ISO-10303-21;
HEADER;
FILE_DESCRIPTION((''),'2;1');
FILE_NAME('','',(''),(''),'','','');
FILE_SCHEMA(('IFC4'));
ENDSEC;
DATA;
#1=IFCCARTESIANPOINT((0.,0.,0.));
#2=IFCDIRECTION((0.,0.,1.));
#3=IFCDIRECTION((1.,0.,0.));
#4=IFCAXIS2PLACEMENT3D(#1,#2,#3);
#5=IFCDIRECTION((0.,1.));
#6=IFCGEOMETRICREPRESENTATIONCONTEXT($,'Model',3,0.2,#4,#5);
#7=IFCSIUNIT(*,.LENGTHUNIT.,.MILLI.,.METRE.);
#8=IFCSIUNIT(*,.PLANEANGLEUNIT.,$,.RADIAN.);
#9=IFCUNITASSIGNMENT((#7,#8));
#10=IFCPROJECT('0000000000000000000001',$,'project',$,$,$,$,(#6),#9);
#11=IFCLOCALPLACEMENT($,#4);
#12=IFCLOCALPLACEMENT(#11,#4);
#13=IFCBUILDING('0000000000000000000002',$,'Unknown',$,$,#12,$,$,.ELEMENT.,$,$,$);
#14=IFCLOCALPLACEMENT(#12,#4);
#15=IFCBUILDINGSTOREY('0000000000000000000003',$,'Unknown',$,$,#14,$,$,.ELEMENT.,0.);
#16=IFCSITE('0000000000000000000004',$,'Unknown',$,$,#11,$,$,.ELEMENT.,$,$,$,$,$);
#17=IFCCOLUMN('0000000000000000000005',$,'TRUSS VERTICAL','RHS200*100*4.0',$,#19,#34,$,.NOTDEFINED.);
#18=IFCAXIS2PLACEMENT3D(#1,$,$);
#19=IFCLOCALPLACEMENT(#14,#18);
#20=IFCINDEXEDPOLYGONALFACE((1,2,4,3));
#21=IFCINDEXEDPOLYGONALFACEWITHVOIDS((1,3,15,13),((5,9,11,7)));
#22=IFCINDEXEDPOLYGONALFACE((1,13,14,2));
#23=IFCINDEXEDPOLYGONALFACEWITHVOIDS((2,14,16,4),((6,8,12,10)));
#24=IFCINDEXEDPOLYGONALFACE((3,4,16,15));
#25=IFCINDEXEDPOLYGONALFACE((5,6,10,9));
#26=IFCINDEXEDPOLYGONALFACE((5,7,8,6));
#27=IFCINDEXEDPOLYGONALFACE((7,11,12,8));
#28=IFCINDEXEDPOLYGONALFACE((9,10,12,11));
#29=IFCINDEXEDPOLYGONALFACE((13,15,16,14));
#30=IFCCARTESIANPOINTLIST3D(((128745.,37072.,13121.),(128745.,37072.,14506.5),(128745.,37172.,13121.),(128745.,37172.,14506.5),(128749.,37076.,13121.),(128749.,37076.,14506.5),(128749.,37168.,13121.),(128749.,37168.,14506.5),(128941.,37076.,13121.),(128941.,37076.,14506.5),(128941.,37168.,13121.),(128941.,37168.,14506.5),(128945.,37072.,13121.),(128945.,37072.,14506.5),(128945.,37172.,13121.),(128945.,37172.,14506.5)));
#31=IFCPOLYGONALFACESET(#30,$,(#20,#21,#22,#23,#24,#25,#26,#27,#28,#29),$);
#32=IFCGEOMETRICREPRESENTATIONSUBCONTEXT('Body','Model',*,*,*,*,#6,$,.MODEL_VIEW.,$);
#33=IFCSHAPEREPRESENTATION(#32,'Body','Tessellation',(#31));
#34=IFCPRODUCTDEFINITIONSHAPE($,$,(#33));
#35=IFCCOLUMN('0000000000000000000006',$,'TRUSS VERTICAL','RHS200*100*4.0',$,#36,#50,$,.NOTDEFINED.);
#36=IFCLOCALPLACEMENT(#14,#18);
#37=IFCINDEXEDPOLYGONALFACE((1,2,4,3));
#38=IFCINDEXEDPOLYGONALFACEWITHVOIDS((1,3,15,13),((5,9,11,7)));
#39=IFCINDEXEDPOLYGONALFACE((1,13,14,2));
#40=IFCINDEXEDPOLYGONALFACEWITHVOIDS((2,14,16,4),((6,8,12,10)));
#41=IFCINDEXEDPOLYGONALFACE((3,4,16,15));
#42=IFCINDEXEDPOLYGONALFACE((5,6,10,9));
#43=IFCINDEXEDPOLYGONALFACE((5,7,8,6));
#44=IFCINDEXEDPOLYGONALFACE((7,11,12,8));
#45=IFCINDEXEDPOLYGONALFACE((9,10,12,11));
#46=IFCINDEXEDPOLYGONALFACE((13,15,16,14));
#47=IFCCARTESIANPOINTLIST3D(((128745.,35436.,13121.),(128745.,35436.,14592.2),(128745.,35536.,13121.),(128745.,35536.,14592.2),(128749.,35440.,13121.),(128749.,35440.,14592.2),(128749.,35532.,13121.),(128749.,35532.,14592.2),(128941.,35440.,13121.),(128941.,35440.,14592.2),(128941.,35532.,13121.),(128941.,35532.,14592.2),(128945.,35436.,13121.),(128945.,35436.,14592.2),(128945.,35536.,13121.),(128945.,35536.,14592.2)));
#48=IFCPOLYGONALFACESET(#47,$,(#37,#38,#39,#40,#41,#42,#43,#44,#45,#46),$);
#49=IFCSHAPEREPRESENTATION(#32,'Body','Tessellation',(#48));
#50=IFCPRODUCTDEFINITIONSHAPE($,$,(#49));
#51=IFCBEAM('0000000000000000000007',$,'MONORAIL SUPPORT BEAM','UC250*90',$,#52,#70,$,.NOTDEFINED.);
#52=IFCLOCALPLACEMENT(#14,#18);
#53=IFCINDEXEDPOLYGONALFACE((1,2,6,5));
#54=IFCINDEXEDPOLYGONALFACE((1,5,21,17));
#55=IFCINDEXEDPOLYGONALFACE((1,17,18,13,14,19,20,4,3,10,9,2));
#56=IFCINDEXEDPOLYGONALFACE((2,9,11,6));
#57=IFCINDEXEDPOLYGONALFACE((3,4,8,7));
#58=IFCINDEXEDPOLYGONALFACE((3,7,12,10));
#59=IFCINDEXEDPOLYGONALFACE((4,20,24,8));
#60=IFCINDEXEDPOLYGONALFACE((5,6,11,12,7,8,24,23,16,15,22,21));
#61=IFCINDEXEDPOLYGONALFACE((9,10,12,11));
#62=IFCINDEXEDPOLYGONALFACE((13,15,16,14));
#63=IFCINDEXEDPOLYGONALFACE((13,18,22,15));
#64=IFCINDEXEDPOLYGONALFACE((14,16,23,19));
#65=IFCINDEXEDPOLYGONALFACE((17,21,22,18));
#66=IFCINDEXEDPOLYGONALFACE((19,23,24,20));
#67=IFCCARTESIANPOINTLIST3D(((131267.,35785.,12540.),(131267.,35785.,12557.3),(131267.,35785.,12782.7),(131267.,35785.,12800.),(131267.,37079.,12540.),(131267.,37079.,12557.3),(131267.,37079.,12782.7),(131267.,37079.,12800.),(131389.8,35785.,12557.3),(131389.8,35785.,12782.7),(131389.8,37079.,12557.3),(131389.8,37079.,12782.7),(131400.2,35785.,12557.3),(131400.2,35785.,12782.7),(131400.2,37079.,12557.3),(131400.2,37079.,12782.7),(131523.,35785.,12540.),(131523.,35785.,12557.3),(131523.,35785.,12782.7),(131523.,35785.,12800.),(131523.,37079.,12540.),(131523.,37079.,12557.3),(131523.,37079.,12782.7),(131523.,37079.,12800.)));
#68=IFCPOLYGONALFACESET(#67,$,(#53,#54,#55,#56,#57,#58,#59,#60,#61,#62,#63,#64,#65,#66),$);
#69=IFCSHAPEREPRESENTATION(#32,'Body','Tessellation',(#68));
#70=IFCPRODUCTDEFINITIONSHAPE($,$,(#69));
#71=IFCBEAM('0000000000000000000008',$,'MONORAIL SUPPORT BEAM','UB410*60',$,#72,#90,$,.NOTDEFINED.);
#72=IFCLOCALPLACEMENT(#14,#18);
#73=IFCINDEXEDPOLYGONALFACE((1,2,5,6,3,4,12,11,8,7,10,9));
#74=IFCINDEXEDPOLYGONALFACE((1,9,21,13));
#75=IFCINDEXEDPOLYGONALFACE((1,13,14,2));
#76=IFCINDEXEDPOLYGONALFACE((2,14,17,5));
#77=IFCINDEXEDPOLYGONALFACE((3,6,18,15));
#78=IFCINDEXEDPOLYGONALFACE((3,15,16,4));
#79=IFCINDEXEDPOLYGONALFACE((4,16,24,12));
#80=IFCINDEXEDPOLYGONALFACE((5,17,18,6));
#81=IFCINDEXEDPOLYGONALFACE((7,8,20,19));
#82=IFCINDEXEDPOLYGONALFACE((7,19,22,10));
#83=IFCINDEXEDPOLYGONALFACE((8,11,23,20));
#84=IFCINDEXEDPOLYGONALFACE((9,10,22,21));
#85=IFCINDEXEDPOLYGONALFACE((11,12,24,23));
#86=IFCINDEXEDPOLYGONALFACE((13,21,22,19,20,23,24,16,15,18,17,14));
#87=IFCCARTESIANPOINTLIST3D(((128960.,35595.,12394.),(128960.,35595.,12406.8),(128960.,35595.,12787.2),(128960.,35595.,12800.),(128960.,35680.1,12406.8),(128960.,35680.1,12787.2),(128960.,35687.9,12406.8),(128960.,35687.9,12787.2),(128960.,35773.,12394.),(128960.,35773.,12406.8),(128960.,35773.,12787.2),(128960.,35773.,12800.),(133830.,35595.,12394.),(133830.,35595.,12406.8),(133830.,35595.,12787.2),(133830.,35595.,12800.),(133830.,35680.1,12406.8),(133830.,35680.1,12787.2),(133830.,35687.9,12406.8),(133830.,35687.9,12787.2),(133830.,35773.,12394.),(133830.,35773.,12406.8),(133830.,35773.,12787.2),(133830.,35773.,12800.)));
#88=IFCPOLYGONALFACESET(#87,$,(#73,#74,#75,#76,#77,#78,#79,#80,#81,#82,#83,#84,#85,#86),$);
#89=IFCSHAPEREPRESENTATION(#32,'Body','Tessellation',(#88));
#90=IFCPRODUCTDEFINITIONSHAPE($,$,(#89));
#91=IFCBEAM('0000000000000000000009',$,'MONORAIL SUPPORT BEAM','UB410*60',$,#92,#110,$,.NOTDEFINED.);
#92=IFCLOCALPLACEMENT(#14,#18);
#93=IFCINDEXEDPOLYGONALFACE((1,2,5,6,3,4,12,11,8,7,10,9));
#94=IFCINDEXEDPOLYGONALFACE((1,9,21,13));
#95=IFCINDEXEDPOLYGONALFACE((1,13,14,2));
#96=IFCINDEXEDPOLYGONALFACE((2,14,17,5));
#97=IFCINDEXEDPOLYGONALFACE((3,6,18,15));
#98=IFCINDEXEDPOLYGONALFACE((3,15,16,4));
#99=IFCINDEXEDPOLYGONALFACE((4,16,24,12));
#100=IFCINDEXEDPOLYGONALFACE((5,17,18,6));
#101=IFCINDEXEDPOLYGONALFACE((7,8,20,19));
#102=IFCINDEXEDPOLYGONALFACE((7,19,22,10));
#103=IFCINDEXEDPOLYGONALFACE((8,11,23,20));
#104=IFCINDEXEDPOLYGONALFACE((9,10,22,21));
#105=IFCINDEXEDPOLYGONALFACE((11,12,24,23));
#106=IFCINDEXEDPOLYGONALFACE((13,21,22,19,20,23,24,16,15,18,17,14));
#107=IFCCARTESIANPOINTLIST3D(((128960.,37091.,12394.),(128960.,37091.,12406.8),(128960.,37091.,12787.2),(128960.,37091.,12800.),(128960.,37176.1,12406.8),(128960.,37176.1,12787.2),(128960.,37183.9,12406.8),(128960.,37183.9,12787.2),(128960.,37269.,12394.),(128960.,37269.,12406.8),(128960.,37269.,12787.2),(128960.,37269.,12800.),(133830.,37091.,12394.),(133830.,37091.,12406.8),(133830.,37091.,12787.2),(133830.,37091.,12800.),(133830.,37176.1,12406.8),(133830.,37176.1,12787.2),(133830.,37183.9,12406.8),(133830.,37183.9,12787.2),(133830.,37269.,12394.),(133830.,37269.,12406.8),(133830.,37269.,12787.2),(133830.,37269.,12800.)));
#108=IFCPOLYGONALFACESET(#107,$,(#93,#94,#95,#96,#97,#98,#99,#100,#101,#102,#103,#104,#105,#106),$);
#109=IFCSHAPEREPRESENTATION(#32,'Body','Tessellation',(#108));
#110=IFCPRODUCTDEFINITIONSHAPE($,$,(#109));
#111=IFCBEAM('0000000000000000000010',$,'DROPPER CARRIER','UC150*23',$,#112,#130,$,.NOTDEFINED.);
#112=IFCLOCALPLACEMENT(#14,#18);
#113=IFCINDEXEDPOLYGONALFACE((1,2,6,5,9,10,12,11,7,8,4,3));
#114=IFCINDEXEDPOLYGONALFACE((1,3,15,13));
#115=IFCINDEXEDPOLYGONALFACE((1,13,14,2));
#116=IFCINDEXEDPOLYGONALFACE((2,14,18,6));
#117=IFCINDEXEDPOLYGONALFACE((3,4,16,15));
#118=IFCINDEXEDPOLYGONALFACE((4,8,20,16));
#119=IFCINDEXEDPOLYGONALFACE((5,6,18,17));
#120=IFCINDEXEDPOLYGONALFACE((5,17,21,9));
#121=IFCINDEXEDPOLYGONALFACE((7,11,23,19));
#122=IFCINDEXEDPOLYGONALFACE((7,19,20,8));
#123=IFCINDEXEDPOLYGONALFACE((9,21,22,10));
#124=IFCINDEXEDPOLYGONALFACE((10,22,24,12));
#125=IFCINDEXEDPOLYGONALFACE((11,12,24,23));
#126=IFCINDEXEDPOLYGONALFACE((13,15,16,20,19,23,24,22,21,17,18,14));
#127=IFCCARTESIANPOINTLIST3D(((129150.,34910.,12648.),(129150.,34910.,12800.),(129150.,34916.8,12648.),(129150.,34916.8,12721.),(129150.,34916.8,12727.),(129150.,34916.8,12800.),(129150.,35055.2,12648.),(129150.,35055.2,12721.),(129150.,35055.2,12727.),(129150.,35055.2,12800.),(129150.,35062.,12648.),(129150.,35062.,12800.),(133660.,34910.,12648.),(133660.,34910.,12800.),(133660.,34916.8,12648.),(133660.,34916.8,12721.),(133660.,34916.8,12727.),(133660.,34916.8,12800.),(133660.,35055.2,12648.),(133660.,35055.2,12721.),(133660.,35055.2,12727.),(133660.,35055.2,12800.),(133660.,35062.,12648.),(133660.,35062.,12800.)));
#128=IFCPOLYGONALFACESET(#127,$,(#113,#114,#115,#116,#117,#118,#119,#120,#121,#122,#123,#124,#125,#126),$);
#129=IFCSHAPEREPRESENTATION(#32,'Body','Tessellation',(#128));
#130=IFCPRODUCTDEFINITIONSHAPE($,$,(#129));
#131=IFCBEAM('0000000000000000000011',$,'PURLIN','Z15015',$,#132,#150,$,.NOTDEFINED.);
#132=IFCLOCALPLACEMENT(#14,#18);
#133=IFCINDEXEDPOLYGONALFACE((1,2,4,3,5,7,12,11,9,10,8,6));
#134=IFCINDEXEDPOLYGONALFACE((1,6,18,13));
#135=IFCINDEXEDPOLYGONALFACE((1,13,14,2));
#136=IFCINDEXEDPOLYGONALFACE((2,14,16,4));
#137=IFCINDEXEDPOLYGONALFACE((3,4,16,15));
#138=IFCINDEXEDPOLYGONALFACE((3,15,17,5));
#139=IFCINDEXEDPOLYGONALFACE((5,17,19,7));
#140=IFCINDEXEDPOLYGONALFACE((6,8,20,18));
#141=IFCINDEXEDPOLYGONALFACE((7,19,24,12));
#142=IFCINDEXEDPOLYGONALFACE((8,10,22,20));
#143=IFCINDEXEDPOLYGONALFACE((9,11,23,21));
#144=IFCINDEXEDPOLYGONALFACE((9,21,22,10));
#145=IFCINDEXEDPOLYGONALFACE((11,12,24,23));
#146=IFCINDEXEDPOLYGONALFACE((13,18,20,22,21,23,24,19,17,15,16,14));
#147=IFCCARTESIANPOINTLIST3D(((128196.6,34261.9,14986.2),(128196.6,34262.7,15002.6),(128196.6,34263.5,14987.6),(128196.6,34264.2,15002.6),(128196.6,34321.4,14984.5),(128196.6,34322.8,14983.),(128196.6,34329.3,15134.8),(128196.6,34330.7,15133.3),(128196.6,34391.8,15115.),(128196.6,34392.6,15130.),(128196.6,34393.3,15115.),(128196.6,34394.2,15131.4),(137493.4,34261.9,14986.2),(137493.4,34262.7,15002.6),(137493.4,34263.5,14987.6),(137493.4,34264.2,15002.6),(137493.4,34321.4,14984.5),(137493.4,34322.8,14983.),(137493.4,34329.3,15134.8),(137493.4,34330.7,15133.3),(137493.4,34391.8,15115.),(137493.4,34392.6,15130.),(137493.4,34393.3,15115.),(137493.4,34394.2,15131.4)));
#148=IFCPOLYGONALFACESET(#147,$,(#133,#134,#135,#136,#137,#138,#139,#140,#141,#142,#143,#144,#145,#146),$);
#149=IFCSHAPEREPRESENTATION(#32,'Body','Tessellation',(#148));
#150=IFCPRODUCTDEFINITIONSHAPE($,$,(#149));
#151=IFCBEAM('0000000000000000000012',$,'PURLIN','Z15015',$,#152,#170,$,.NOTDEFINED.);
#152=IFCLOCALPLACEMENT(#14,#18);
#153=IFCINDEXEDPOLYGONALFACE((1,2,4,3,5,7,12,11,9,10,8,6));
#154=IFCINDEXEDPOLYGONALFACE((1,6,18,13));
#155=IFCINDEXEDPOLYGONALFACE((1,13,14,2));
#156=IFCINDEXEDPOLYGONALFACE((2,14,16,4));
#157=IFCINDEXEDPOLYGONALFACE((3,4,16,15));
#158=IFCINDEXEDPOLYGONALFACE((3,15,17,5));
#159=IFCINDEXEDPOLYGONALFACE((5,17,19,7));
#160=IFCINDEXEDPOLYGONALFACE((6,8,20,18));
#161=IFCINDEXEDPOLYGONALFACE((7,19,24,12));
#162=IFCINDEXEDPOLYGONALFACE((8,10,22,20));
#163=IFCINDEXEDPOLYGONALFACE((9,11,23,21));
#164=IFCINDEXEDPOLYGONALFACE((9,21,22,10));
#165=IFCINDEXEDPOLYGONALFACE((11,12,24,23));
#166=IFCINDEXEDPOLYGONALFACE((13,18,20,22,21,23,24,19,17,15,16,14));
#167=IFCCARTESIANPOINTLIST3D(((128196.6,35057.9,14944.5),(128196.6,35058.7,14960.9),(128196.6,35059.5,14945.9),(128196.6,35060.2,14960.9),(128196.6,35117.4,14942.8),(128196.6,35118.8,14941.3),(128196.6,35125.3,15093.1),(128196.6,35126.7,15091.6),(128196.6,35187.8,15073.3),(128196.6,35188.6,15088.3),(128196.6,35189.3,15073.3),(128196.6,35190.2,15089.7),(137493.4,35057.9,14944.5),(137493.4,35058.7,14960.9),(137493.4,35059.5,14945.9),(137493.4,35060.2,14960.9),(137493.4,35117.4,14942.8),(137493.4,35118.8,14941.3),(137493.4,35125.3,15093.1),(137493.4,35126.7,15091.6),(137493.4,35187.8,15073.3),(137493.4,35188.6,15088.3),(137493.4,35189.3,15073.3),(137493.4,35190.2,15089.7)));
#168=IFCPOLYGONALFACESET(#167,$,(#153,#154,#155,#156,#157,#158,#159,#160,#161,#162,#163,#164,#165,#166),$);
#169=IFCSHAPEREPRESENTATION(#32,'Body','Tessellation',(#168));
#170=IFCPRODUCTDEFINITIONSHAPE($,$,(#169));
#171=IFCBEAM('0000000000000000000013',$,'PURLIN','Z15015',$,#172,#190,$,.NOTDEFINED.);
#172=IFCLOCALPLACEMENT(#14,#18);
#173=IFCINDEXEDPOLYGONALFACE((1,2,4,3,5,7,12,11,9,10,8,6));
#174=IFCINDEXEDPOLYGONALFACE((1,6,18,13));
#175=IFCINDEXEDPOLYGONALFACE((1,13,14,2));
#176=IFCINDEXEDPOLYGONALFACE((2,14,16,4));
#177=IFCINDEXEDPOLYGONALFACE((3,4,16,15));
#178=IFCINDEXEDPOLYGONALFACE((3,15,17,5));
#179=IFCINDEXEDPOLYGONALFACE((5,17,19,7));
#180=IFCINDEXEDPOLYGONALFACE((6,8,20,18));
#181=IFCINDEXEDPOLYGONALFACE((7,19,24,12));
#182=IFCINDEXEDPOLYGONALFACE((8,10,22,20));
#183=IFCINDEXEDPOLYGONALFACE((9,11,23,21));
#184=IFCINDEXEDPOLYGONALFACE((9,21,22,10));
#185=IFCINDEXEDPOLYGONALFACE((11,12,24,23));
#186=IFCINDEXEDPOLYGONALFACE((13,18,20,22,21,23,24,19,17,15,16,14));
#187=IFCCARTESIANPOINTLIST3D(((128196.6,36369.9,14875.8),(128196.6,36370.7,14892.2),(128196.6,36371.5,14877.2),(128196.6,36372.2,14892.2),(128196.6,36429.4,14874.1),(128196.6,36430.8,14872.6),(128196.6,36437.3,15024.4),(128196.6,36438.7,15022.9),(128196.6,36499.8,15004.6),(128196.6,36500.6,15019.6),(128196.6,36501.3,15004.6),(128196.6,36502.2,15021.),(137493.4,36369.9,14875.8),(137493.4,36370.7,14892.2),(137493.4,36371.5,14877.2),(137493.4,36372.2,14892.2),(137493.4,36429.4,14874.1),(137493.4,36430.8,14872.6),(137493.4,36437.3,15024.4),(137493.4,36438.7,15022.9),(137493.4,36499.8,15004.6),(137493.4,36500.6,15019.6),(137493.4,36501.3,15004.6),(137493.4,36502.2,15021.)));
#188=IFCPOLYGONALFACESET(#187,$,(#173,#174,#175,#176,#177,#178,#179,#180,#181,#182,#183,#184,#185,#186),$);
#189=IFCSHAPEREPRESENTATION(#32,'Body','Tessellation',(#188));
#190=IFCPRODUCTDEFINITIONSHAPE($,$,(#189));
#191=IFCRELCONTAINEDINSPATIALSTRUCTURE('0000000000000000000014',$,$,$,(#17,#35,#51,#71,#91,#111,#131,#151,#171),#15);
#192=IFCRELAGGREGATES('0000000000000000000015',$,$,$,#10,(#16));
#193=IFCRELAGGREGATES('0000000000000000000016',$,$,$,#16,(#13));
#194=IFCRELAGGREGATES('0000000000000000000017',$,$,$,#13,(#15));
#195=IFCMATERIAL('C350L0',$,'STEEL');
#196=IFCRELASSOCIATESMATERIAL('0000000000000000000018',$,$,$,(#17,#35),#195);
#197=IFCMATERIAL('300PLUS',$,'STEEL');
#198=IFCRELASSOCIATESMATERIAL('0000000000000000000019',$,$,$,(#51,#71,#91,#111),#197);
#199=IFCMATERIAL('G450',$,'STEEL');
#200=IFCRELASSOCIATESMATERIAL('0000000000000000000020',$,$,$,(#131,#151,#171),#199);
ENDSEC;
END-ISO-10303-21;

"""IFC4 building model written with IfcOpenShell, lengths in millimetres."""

from ifc_helpers import new_model, si_unit, direction, frame, origin_with_axes, place, context, subcontext, project, spatial, line, indexed_curve, outline, extrude, material, element, save


model = new_model("IFC4")

# Units and contexts
model_context = context("Model", 3, precision=0.2, world=origin_with_axes(), true_north=direction((0.0, 1.0)))
body_context = subcontext(model_context, "Body", "Model", "MODEL_VIEW")
ifc_project = project(units=[si_unit("LENGTHUNIT", "METRE", prefix="MILLI"), si_unit("PLANEANGLEUNIT", "RADIAN")], contexts=[model_context])

# Site, building, storey
site_placement = place(None, origin_with_axes())
site = spatial("IfcSite", under=ifc_project, at=site_placement, Name="Unknown", CompositionType="ELEMENT")
building_placement = place(site_placement, origin_with_axes())
building = spatial("IfcBuilding", under=site, at=building_placement, Name="Unknown", CompositionType="ELEMENT")
storey_placement = place(building_placement, origin_with_axes())
storey = spatial("IfcBuildingStorey", under=building, at=storey_placement, Name="Unknown", CompositionType="ELEMENT", Elevation=0.0)

# Columns
ifc_material_1 = material(Name="C350L0", Category="STEEL")
column_1_placement = place(storey_placement, frame((128845.0, 37122.0, 13121.0), z_axis=(0.0, -1.0, 0.0), x_axis=(0.0, 0.0, 1.0)))
element("IfcColumn", 1, at=column_1_placement, inside=storey, material=ifc_material_1, Name="TRUSS VERTICAL", Description="RHS200*100*4.0", PredefinedType="NOTDEFINED", context=body_context, shape_type="SolidModel", body=[
    extrude(outline(indexed_curve([(-50.0, -100.0), (50.0, -100.0), (50.0, 100.0), (-50.0, 100.0)], segments=[line(1, 2, 3, 4, 1)]), holes=[indexed_curve([(-46.0, -96.0), (-46.0, 96.0), (46.0, 96.0), (46.0, -96.0)], segments=[line(1, 2, 3, 4, 1)])]), frame((0.0, 0.0, 0.0), z_axis=(-1.0, 0.0, 0.0), x_axis=(0.0, 0.0, 1.0)), (0.0, 0.0, -1.0), 1385.5),
])
column_2_placement = place(storey_placement, frame((128845.0, 35486.0, 13121.0), z_axis=(0.0, -1.0, 0.0), x_axis=(0.0, 0.0, 1.0)))
element("IfcColumn", 2, at=column_2_placement, inside=storey, material=ifc_material_1, Name="TRUSS VERTICAL", Description="RHS200*100*4.0", PredefinedType="NOTDEFINED", context=body_context, shape_type="SolidModel", body=[
    extrude(outline(indexed_curve([(-50.0, -100.0), (50.0, -100.0), (50.0, 100.0), (-50.0, 100.0)], segments=[line(1, 2, 3, 4, 1)]), holes=[indexed_curve([(-46.0, -96.0), (-46.0, 96.0), (46.0, 96.0), (46.0, -96.0)], segments=[line(1, 2, 3, 4, 1)])]), frame((0.0, 0.0, 0.0), z_axis=(-1.0, 0.0, 0.0), x_axis=(0.0, 0.0, 1.0)), (0.0, 0.0, -1.0), 1471.2),
])

# Beams
ifc_material_2 = material(Name="300PLUS", Category="STEEL")
beam_1_placement = place(storey_placement, frame((131395.0, 35785.0, 12670.0), z_axis=(1.0, 0.0, 0.0), x_axis=(0.0, 1.0, 0.0)))
element("IfcBeam", 3, at=beam_1_placement, inside=storey, material=ifc_material_2, Name="MONORAIL SUPPORT BEAM", Description="UC250*90", PredefinedType="NOTDEFINED", context=body_context, shape_type="SolidModel", body=[
    extrude(outline(indexed_curve([(-128.0, -130.0), (128.0, -130.0), (128.0, -112.7), (5.2, -112.7), (5.2, 112.7), (128.0, 112.7), (128.0, 130.0), (-128.0, 130.0), (-128.0, 112.7), (-5.2, 112.7), (-5.2, -112.7), (-128.0, -112.7)], segments=[line(1, 2, 3, 4, 5, 6, 7, 8, 9, 10, 11, 12, 1)])), frame((0.0, 0.0, 0.0), z_axis=(-1.0, 0.0, 0.0), x_axis=(0.0, 0.0, 1.0)), (0.0, 0.0, -1.0), 1294.0),
])
for number, where, z_axis, x_axis, name in (
    (4, (128960.0, 35684.0, 12597.0), (0.0, -1.0, 0.0), (1.0, 0.0, 0.0), "MONORAIL SUPPORT BEAM"),
    (5, (128960.0, 37180.0, 12597.0), (0.0, -1.0, 0.0), (1.0, 0.0, 0.0), "MONORAIL SUPPORT BEAM"),
):
    element("IfcBeam", number, at=place(storey_placement, frame(where, z_axis=z_axis, x_axis=x_axis)), inside=storey, material=ifc_material_2, Name=name, Description="UB410*60", PredefinedType="NOTDEFINED", context=body_context, shape_type="SolidModel", body=[
        extrude(outline(indexed_curve([(-89.0, -203.0), (89.0, -203.0), (89.0, -190.2), (3.9, -190.2), (3.9, 190.2), (89.0, 190.2), (89.0, 203.0), (-89.0, 203.0), (-89.0, 190.2), (-3.9, 190.2), (-3.9, -190.2), (-89.0, -190.2)], segments=[line(1, 2, 3, 4, 5, 6, 7, 8, 9, 10, 11, 12, 1)])), frame((0.0, 0.0, 0.0), z_axis=(-1.0, 0.0, 0.0), x_axis=(0.0, 0.0, 1.0)), (0.0, 0.0, -1.0), 4870.0),
    ])
beam_2_placement = place(storey_placement, frame((129150.0, 34986.0, 12724.0), z_axis=(0.0, 0.0, 1.0), x_axis=(1.0, 0.0, 0.0)))
element("IfcBeam", 6, at=beam_2_placement, inside=storey, material=ifc_material_2, Name="DROPPER CARRIER", Description="UC150*23", PredefinedType="NOTDEFINED", context=body_context, shape_type="SolidModel", body=[
    extrude(outline(indexed_curve([(-76.0, -76.0), (76.0, -76.0), (76.0, -69.2), (3.0, -69.2), (3.0, 69.2), (76.0, 69.2), (76.0, 76.0), (-76.0, 76.0), (-76.0, 69.2), (-3.0, 69.2), (-3.0, -69.2), (-76.0, -69.2)], segments=[line(1, 2, 3, 4, 5, 6, 7, 8, 9, 10, 11, 12, 1)])), frame((0.0, 0.0, 0.0), z_axis=(-1.0, 0.0, 0.0), x_axis=(0.0, 0.0, 1.0)), (0.0, 0.0, -1.0), 4510.0),
])
ifc_material_3 = material(Name="G450", Category="STEEL")
for number, where, z_axis, x_axis, name in (
    (7, (128196.6, 34326.0, 15058.9), (0.0, -0.99863, 0.052336), (1.0, 0.0, 0.0), "PURLIN"),
    (8, (128196.6, 35122.0, 15017.2), (0.0, -0.99863, 0.052336), (1.0, 0.0, 0.0), "PURLIN"),
    (9, (128196.6, 36434.0, 14948.5), (0.0, -0.99863, 0.052336), (1.0, 0.0, 0.0), "PURLIN"),
):
    element("IfcBeam", number, at=place(storey_placement, frame(where, z_axis=z_axis, x_axis=x_axis)), inside=storey, material=ifc_material_3, Name=name, Description="Z15015", PredefinedType="NOTDEFINED", context=body_context, shape_type="SolidModel", body=[
        extrude(outline(indexed_curve([(60.2, -76.0), (60.2, -59.5), (58.8, -59.5), (58.8, -74.5), (0.8, -74.5), (0.8, 76.0), (-64.2, 76.0), (-64.2, 59.5), (-62.8, 59.5), (-62.8, 74.5), (-0.8, 74.5), (-0.8, -76.0)], segments=[line(1, 2, 3, 4, 5, 6, 7, 8, 9, 10, 11, 12, 1)])), frame((0.0, 0.0, 0.0), z_axis=(-1.0, 0.0, 0.0), x_axis=(0.0, 0.0, 1.0)), (0.0, 0.0, -1.0), 9296.8),
    ])

save(model, "model.ifc")
